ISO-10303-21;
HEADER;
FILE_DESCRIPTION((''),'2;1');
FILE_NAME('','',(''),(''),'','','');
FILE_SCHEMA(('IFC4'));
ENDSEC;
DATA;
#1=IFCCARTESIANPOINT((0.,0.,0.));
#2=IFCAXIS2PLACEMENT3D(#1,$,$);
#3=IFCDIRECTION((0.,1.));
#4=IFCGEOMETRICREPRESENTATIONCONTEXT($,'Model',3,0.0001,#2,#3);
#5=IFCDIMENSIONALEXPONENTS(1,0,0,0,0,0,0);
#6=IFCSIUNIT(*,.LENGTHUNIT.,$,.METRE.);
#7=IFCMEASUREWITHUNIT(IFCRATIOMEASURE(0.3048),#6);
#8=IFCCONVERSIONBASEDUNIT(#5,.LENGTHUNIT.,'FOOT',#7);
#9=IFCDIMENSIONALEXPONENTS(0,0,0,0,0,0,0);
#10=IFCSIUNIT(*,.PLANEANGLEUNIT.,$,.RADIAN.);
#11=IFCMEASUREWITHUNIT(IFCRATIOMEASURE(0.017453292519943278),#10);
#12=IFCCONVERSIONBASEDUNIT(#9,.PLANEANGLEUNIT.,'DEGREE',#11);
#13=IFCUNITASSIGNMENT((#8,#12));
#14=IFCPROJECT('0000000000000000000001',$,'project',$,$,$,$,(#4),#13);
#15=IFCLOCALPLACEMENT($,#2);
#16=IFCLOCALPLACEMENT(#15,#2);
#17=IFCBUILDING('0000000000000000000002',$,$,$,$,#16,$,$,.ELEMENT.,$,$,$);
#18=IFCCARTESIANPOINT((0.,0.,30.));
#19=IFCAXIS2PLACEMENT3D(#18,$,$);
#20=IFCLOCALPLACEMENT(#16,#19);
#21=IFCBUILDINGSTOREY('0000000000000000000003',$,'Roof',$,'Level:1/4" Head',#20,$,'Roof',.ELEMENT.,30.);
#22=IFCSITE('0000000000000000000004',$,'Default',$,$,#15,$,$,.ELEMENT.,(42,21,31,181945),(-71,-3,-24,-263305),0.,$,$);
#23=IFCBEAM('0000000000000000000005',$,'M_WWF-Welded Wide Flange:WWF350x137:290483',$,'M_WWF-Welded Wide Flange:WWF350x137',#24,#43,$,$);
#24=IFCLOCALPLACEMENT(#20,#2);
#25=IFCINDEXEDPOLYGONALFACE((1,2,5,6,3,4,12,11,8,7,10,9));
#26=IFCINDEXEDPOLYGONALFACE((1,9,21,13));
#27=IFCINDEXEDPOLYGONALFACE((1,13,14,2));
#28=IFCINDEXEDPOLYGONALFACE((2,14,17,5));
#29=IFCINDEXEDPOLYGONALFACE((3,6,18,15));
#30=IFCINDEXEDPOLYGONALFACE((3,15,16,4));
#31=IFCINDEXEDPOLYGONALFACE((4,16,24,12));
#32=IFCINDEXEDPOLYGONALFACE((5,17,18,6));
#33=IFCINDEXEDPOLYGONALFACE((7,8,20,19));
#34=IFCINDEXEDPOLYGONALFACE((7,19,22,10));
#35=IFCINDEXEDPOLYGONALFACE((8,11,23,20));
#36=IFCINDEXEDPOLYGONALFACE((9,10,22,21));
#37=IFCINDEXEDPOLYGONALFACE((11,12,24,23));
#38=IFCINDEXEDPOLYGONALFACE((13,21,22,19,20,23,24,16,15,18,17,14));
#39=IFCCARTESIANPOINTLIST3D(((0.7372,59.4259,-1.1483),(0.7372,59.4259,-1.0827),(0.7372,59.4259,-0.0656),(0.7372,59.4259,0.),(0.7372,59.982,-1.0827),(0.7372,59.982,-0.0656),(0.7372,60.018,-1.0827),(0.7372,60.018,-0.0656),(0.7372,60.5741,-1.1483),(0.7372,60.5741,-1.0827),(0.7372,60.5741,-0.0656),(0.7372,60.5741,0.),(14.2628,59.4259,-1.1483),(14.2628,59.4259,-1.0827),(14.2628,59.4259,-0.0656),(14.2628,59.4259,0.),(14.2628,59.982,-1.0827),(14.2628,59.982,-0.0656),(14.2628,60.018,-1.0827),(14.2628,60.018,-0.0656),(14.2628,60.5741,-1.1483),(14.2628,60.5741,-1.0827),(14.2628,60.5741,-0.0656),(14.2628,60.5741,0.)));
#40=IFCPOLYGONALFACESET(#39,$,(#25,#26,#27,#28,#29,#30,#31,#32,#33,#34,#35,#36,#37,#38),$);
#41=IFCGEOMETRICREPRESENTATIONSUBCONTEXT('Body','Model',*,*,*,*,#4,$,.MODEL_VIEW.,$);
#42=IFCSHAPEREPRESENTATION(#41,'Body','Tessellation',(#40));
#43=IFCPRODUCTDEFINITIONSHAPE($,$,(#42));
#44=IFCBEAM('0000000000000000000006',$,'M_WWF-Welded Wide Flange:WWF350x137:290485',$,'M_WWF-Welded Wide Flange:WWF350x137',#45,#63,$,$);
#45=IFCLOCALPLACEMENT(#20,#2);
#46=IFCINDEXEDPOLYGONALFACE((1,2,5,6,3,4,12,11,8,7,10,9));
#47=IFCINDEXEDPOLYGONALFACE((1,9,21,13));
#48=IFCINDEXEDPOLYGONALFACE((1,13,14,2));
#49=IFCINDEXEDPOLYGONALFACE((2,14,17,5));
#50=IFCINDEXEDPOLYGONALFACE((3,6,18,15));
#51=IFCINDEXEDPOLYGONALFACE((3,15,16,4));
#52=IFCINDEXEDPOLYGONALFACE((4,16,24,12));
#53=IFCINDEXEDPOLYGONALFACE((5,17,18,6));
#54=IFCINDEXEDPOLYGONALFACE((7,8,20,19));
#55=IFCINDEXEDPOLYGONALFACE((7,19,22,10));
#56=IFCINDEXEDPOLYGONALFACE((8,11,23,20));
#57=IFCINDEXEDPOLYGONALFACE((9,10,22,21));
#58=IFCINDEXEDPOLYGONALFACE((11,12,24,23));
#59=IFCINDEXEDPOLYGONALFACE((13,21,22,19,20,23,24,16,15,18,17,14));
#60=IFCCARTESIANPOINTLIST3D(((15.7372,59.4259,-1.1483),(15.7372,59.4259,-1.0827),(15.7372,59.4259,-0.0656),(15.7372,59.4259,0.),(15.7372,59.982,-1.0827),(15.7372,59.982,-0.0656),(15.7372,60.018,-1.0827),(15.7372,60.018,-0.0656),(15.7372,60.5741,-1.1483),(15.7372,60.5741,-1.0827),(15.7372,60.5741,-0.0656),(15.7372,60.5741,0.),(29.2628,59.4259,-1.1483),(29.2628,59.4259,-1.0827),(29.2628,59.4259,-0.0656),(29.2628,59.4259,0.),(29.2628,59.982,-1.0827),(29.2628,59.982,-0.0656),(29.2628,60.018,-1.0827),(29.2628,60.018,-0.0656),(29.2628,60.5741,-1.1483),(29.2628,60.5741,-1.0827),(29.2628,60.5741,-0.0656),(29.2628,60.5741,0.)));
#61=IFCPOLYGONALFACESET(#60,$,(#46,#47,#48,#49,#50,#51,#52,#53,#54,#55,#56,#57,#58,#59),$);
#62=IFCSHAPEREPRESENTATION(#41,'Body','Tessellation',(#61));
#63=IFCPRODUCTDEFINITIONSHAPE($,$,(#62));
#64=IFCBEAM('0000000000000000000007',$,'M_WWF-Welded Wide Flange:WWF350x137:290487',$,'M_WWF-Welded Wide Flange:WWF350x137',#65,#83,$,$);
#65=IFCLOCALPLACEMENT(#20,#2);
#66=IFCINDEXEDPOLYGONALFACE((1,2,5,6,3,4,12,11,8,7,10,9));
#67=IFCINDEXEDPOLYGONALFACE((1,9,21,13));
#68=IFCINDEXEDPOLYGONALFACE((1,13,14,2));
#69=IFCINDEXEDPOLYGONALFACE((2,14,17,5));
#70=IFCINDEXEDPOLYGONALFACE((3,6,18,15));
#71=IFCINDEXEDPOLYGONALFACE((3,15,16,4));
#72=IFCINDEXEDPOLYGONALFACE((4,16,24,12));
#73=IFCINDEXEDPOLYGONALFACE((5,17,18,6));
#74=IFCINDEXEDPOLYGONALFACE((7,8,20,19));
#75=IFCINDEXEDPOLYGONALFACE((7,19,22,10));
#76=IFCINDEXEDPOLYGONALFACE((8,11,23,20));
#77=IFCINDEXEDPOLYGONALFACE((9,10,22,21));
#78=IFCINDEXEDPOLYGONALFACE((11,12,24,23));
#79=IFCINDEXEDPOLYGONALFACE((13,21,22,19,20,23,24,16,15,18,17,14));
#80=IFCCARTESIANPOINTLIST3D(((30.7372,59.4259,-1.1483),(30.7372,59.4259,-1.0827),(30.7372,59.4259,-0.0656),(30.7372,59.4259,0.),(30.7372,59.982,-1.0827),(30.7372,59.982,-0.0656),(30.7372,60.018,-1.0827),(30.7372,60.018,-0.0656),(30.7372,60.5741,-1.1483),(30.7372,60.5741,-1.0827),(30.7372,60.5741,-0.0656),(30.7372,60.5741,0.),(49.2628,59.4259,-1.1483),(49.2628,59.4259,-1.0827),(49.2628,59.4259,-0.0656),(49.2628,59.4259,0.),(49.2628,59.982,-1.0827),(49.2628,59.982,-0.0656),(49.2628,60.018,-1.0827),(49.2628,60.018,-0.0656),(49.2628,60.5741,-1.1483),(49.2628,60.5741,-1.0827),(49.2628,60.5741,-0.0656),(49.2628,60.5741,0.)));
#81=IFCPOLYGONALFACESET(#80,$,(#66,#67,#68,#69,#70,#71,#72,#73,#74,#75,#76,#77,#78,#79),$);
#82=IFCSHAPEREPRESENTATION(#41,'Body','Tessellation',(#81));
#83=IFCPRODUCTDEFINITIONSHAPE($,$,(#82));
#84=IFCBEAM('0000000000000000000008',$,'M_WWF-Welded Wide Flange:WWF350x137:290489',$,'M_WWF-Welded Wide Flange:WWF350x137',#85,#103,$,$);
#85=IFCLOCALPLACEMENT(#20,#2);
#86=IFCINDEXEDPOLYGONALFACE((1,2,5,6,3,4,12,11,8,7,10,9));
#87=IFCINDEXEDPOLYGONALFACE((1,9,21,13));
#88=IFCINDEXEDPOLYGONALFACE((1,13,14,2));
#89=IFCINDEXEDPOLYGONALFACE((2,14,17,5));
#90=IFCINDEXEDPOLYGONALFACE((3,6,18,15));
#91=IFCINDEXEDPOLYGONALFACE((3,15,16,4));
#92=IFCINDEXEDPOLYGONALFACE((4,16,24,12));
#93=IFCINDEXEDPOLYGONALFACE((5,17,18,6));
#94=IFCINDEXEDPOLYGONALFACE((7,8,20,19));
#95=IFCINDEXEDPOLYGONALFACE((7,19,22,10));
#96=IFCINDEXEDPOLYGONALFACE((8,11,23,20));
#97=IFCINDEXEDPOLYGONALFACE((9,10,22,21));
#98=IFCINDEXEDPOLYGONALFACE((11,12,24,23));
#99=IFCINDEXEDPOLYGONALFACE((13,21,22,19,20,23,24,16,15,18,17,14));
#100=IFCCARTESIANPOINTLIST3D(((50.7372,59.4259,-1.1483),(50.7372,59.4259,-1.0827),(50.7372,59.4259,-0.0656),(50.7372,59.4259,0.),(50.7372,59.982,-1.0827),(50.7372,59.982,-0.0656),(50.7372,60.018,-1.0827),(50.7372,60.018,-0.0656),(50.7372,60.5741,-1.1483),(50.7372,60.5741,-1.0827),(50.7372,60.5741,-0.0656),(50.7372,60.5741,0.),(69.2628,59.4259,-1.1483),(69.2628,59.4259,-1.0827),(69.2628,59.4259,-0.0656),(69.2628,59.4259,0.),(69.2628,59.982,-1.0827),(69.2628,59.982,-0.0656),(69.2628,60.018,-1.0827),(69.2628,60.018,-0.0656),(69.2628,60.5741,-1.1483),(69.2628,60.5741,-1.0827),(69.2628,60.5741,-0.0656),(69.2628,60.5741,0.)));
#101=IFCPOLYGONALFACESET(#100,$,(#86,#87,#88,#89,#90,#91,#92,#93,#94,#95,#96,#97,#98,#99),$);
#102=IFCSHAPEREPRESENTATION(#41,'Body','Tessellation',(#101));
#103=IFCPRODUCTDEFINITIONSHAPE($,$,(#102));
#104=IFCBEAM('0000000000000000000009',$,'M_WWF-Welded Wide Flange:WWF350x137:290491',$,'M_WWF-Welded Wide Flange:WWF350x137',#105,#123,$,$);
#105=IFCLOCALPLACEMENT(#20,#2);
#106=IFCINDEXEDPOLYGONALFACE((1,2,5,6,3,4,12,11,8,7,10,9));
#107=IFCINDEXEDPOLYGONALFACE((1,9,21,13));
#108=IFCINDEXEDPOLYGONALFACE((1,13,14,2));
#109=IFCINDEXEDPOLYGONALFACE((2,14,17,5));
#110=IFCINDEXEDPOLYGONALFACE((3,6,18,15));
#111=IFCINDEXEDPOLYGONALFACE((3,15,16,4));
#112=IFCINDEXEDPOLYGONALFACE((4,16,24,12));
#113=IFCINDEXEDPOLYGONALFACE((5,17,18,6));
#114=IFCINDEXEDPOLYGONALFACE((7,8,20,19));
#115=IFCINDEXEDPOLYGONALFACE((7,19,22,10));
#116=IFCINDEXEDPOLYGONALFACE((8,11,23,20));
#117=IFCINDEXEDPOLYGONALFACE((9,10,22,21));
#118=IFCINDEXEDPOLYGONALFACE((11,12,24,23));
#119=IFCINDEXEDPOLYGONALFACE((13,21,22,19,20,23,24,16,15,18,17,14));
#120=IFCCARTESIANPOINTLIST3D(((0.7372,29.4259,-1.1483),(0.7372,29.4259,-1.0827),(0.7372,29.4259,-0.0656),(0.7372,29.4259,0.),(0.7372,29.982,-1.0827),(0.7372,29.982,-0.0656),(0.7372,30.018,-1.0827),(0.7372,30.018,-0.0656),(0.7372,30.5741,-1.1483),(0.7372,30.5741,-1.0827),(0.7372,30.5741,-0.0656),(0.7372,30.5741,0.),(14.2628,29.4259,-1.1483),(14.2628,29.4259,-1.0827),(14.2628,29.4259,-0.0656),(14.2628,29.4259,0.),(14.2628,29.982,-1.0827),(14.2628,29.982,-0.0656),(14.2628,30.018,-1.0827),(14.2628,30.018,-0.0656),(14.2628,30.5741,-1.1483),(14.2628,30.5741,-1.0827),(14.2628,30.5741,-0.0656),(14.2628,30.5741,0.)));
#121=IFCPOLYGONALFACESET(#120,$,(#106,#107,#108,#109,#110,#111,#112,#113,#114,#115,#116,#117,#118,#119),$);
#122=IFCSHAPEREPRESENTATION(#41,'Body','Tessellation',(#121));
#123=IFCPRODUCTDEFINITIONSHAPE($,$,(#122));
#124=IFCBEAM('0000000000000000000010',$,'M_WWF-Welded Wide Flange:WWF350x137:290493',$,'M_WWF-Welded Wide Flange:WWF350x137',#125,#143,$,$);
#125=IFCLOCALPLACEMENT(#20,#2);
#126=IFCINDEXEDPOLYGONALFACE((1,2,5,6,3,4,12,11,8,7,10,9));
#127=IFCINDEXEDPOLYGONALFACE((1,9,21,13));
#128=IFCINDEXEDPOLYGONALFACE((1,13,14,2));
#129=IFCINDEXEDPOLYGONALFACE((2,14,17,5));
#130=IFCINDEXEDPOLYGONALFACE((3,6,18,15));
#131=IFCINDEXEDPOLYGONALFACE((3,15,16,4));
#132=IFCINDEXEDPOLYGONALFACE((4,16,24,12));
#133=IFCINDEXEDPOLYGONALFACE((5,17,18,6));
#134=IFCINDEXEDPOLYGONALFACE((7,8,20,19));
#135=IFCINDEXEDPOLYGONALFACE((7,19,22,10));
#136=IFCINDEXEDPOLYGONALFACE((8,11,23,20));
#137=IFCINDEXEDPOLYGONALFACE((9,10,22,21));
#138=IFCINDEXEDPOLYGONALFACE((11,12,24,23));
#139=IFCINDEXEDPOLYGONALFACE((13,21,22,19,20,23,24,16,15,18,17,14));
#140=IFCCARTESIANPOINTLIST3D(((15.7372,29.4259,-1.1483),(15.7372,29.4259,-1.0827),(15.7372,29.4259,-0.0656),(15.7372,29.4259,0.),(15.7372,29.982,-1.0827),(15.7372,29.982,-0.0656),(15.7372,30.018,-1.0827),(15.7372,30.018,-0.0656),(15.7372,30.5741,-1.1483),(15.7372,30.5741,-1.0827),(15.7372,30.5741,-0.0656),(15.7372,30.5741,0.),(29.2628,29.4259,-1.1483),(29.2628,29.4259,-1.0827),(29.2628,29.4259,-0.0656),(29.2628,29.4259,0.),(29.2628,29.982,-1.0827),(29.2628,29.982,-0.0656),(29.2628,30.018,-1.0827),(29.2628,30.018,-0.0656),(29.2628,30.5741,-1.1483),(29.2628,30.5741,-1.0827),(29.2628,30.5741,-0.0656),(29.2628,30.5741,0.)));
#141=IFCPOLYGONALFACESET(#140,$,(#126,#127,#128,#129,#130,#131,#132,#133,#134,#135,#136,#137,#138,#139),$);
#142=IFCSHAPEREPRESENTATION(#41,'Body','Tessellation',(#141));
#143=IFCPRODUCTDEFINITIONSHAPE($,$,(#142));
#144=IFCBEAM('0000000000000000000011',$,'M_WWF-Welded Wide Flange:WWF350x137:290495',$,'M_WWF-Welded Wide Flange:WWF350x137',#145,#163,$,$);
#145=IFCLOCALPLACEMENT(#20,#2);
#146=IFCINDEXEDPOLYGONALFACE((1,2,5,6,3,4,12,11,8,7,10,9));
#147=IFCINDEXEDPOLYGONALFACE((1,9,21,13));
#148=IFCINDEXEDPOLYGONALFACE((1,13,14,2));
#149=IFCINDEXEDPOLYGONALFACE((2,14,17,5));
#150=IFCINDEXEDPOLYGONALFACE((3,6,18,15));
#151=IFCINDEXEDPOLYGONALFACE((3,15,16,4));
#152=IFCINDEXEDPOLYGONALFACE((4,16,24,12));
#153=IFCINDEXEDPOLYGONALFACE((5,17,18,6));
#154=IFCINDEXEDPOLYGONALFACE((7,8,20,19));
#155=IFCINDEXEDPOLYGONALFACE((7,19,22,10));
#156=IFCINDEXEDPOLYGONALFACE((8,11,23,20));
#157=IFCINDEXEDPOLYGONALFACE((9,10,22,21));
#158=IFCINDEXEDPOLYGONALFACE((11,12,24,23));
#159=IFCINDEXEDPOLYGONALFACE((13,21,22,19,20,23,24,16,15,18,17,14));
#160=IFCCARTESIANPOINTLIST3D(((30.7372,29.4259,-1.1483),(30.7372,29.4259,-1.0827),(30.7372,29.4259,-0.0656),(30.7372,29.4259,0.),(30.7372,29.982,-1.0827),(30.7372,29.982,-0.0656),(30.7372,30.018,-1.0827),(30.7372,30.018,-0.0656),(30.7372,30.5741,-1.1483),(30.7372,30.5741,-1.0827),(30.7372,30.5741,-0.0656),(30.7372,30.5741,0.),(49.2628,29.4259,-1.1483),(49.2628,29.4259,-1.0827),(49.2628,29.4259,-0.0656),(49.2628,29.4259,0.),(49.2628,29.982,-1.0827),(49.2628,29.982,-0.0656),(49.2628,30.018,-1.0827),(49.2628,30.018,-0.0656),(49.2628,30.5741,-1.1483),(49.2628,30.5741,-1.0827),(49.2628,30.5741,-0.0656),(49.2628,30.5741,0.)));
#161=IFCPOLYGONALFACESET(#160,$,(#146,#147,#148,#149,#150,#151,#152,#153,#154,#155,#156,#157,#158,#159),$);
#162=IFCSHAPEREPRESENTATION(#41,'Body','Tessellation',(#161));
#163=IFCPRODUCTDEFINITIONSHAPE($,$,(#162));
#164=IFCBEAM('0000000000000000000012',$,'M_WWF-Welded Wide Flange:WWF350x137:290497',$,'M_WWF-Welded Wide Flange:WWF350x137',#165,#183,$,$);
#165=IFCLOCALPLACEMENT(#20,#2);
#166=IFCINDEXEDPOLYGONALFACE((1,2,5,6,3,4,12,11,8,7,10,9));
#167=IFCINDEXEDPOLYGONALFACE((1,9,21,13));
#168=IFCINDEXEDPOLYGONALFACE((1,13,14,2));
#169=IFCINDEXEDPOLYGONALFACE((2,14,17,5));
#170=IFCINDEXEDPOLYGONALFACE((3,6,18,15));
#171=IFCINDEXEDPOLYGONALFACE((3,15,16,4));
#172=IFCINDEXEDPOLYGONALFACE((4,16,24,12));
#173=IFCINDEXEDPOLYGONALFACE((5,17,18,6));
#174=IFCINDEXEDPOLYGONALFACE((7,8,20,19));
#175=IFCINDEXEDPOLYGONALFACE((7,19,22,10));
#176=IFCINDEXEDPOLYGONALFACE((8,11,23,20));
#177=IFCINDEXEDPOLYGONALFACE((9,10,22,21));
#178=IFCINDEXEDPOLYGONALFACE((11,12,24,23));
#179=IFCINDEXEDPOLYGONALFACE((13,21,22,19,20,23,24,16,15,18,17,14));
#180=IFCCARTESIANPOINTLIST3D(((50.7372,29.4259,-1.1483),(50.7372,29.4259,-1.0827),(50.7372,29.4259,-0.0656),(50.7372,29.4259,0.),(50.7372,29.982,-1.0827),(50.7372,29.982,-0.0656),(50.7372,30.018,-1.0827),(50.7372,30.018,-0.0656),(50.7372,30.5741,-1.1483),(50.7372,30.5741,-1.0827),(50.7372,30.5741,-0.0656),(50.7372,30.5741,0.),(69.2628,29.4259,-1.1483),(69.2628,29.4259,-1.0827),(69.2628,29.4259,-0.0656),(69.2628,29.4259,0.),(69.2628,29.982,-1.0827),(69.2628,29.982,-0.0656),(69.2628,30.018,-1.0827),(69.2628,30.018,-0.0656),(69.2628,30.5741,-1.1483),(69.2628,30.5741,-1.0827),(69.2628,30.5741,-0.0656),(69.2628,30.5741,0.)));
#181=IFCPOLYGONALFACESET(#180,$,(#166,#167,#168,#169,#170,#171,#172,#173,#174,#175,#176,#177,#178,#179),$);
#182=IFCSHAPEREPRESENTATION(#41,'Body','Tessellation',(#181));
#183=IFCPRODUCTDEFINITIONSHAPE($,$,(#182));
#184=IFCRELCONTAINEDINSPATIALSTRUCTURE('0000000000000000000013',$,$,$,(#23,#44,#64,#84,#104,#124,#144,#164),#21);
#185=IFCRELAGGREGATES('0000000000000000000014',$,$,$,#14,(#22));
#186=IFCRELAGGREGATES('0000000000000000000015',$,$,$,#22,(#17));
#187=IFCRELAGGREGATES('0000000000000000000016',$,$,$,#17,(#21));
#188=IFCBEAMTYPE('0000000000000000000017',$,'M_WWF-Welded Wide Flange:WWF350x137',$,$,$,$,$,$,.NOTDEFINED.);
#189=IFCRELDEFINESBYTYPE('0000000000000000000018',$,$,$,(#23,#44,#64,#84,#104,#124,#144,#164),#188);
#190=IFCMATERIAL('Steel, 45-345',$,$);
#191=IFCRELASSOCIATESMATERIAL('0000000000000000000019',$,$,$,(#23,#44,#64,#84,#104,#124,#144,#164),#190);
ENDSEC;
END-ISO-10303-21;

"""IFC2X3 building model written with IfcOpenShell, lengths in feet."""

from ifc_helpers import new_model, entity, si_unit, converted_unit, direction, frame, frame_2d, origin, place, context, subcontext, project, spatial, i_section, extrude, material, type_object, element, save


model = new_model("IFC2X3")

# Units and contexts
model_context = context("Model", 3, precision=0.0001, world=origin(), true_north=direction((0.0, 1.0)))
body_context = subcontext(model_context, "Body", "Model", "MODEL_VIEW")
ifc_project = project(units=[converted_unit("LENGTHUNIT", "FOOT", entity("IfcRatioMeasure", 0.3048), si_unit("LENGTHUNIT", "METRE"), dimensions=[1, 0, 0, 0, 0, 0, 0]), converted_unit("PLANEANGLEUNIT", "DEGREE", entity("IfcRatioMeasure", 0.017453292519943278), si_unit("PLANEANGLEUNIT", "RADIAN"), dimensions=[0, 0, 0, 0, 0, 0, 0])], contexts=[model_context])

# Site, building, storey
site_placement = place(None, origin())
site = spatial("IfcSite", under=ifc_project, at=site_placement, Name="Default", CompositionType="ELEMENT", RefLatitude=(42, 21, 31, 181945), RefLongitude=(-71, -3, -24, -263305), RefElevation=0.0)
building_placement = place(site_placement, origin())
building = spatial("IfcBuilding", under=site, at=building_placement, CompositionType="ELEMENT")
storey_placement = place(building_placement, frame((0.0, 0.0, 30.0)))
storey = spatial("IfcBuildingStorey", under=building, at=storey_placement, Name="Roof", ObjectType="Level:1/4\" Head", LongName="Roof", CompositionType="ELEMENT", Elevation=30.0)

# Beams
ifc_material = material(Name="Steel, 45-345")
beam_type = type_object("IfcBeamType", Name="M_WWF-Welded Wide Flange:WWF350x137", PredefinedType="NOTDEFINED")
beam_1_placement = place(storey_placement, frame((0.0, 60.0, 0.0)))
element("IfcBeam", 1, at=beam_1_placement, inside=storey, type_object=beam_type, material=ifc_material, Name="M_WWF-Welded Wide Flange:WWF350x137:290483", ObjectType="M_WWF-Welded Wide Flange:WWF350x137", context=body_context, shape_type="SweptSolid", body=[
    extrude(i_section(OverallWidth=1.1483, OverallDepth=1.1483, WebThickness=0.0361, FlangeThickness=0.0656, at=frame_2d((0.0, 0.0), x_axis=(0.0, 1.0))), frame((0.7372, 0.0, -0.5741), z_axis=(1.0, 0.0, 0.0), x_axis=(0.0, 0.0, -1.0)), (0.0, 0.0, 1.0), 13.5256),
])
beam_2_placement = place(storey_placement, frame((15.0, 60.0, 0.0)))
element("IfcBeam", 2, at=beam_2_placement, inside=storey, type_object=beam_type, material=ifc_material, Name="M_WWF-Welded Wide Flange:WWF350x137:290485", ObjectType="M_WWF-Welded Wide Flange:WWF350x137", context=body_context, shape_type="SweptSolid", body=[
    extrude(i_section(OverallWidth=1.1483, OverallDepth=1.1483, WebThickness=0.0361, FlangeThickness=0.0656, at=frame_2d((0.0, 0.0), x_axis=(0.0, 1.0))), frame((0.7372, 0.0, -0.5741), z_axis=(1.0, 0.0, 0.0), x_axis=(0.0, 0.0, -1.0)), (0.0, 0.0, 1.0), 13.5256),
])
beam_3_placement = place(storey_placement, frame((30.0, 60.0, 0.0)))
element("IfcBeam", 3, at=beam_3_placement, inside=storey, type_object=beam_type, material=ifc_material, Name="M_WWF-Welded Wide Flange:WWF350x137:290487", ObjectType="M_WWF-Welded Wide Flange:WWF350x137", context=body_context, shape_type="SweptSolid", body=[
    extrude(i_section(OverallWidth=1.1483, OverallDepth=1.1483, WebThickness=0.0361, FlangeThickness=0.0656, at=frame_2d((0.0, 0.0), x_axis=(0.0, 1.0))), frame((0.7372, 0.0, -0.5741), z_axis=(1.0, 0.0, 0.0), x_axis=(0.0, 0.0, -1.0)), (0.0, 0.0, 1.0), 18.5256),
])
beam_4_placement = place(storey_placement, frame((50.0, 60.0, 0.0)))
element("IfcBeam", 4, at=beam_4_placement, inside=storey, type_object=beam_type, material=ifc_material, Name="M_WWF-Welded Wide Flange:WWF350x137:290489", ObjectType="M_WWF-Welded Wide Flange:WWF350x137", context=body_context, shape_type="SweptSolid", body=[
    extrude(i_section(OverallWidth=1.1483, OverallDepth=1.1483, WebThickness=0.0361, FlangeThickness=0.0656, at=frame_2d((0.0, 0.0), x_axis=(0.0, 1.0))), frame((0.7372, 0.0, -0.5741), z_axis=(1.0, 0.0, 0.0), x_axis=(0.0, 0.0, -1.0)), (0.0, 0.0, 1.0), 18.5256),
])
beam_5_placement = place(storey_placement, frame((0.0, 30.0, 0.0)))
element("IfcBeam", 5, at=beam_5_placement, inside=storey, type_object=beam_type, material=ifc_material, Name="M_WWF-Welded Wide Flange:WWF350x137:290491", ObjectType="M_WWF-Welded Wide Flange:WWF350x137", context=body_context, shape_type="SweptSolid", body=[
    extrude(i_section(OverallWidth=1.1483, OverallDepth=1.1483, WebThickness=0.0361, FlangeThickness=0.0656, at=frame_2d((0.0, 0.0), x_axis=(0.0, 1.0))), frame((0.7372, 0.0, -0.5741), z_axis=(1.0, 0.0, 0.0), x_axis=(0.0, 0.0, -1.0)), (0.0, 0.0, 1.0), 13.5256),
])
beam_6_placement = place(storey_placement, frame((15.0, 30.0, 0.0)))
element("IfcBeam", 6, at=beam_6_placement, inside=storey, type_object=beam_type, material=ifc_material, Name="M_WWF-Welded Wide Flange:WWF350x137:290493", ObjectType="M_WWF-Welded Wide Flange:WWF350x137", context=body_context, shape_type="SweptSolid", body=[
    extrude(i_section(OverallWidth=1.1483, OverallDepth=1.1483, WebThickness=0.0361, FlangeThickness=0.0656, at=frame_2d((0.0, 0.0), x_axis=(0.0, 1.0))), frame((0.7372, 0.0, -0.5741), z_axis=(1.0, 0.0, 0.0), x_axis=(0.0, 0.0, -1.0)), (0.0, 0.0, 1.0), 13.5256),
])
beam_7_placement = place(storey_placement, frame((30.0, 30.0, 0.0)))
element("IfcBeam", 7, at=beam_7_placement, inside=storey, type_object=beam_type, material=ifc_material, Name="M_WWF-Welded Wide Flange:WWF350x137:290495", ObjectType="M_WWF-Welded Wide Flange:WWF350x137", context=body_context, shape_type="SweptSolid", body=[
    extrude(i_section(OverallWidth=1.1483, OverallDepth=1.1483, WebThickness=0.0361, FlangeThickness=0.0656, at=frame_2d((0.0, 0.0), x_axis=(0.0, 1.0))), frame((0.7372, 0.0, -0.5741), z_axis=(1.0, 0.0, 0.0), x_axis=(0.0, 0.0, -1.0)), (0.0, 0.0, 1.0), 18.5256),
])
beam_8_placement = place(storey_placement, frame((50.0, 30.0, 0.0)))
element("IfcBeam", 8, at=beam_8_placement, inside=storey, type_object=beam_type, material=ifc_material, Name="M_WWF-Welded Wide Flange:WWF350x137:290497", ObjectType="M_WWF-Welded Wide Flange:WWF350x137", context=body_context, shape_type="SweptSolid", body=[
    extrude(i_section(OverallWidth=1.1483, OverallDepth=1.1483, WebThickness=0.0361, FlangeThickness=0.0656, at=frame_2d((0.0, 0.0), x_axis=(0.0, 1.0))), frame((0.7372, 0.0, -0.5741), z_axis=(1.0, 0.0, 0.0), x_axis=(0.0, 0.0, -1.0)), (0.0, 0.0, 1.0), 18.5256),
])

save(model, "model.ifc")
